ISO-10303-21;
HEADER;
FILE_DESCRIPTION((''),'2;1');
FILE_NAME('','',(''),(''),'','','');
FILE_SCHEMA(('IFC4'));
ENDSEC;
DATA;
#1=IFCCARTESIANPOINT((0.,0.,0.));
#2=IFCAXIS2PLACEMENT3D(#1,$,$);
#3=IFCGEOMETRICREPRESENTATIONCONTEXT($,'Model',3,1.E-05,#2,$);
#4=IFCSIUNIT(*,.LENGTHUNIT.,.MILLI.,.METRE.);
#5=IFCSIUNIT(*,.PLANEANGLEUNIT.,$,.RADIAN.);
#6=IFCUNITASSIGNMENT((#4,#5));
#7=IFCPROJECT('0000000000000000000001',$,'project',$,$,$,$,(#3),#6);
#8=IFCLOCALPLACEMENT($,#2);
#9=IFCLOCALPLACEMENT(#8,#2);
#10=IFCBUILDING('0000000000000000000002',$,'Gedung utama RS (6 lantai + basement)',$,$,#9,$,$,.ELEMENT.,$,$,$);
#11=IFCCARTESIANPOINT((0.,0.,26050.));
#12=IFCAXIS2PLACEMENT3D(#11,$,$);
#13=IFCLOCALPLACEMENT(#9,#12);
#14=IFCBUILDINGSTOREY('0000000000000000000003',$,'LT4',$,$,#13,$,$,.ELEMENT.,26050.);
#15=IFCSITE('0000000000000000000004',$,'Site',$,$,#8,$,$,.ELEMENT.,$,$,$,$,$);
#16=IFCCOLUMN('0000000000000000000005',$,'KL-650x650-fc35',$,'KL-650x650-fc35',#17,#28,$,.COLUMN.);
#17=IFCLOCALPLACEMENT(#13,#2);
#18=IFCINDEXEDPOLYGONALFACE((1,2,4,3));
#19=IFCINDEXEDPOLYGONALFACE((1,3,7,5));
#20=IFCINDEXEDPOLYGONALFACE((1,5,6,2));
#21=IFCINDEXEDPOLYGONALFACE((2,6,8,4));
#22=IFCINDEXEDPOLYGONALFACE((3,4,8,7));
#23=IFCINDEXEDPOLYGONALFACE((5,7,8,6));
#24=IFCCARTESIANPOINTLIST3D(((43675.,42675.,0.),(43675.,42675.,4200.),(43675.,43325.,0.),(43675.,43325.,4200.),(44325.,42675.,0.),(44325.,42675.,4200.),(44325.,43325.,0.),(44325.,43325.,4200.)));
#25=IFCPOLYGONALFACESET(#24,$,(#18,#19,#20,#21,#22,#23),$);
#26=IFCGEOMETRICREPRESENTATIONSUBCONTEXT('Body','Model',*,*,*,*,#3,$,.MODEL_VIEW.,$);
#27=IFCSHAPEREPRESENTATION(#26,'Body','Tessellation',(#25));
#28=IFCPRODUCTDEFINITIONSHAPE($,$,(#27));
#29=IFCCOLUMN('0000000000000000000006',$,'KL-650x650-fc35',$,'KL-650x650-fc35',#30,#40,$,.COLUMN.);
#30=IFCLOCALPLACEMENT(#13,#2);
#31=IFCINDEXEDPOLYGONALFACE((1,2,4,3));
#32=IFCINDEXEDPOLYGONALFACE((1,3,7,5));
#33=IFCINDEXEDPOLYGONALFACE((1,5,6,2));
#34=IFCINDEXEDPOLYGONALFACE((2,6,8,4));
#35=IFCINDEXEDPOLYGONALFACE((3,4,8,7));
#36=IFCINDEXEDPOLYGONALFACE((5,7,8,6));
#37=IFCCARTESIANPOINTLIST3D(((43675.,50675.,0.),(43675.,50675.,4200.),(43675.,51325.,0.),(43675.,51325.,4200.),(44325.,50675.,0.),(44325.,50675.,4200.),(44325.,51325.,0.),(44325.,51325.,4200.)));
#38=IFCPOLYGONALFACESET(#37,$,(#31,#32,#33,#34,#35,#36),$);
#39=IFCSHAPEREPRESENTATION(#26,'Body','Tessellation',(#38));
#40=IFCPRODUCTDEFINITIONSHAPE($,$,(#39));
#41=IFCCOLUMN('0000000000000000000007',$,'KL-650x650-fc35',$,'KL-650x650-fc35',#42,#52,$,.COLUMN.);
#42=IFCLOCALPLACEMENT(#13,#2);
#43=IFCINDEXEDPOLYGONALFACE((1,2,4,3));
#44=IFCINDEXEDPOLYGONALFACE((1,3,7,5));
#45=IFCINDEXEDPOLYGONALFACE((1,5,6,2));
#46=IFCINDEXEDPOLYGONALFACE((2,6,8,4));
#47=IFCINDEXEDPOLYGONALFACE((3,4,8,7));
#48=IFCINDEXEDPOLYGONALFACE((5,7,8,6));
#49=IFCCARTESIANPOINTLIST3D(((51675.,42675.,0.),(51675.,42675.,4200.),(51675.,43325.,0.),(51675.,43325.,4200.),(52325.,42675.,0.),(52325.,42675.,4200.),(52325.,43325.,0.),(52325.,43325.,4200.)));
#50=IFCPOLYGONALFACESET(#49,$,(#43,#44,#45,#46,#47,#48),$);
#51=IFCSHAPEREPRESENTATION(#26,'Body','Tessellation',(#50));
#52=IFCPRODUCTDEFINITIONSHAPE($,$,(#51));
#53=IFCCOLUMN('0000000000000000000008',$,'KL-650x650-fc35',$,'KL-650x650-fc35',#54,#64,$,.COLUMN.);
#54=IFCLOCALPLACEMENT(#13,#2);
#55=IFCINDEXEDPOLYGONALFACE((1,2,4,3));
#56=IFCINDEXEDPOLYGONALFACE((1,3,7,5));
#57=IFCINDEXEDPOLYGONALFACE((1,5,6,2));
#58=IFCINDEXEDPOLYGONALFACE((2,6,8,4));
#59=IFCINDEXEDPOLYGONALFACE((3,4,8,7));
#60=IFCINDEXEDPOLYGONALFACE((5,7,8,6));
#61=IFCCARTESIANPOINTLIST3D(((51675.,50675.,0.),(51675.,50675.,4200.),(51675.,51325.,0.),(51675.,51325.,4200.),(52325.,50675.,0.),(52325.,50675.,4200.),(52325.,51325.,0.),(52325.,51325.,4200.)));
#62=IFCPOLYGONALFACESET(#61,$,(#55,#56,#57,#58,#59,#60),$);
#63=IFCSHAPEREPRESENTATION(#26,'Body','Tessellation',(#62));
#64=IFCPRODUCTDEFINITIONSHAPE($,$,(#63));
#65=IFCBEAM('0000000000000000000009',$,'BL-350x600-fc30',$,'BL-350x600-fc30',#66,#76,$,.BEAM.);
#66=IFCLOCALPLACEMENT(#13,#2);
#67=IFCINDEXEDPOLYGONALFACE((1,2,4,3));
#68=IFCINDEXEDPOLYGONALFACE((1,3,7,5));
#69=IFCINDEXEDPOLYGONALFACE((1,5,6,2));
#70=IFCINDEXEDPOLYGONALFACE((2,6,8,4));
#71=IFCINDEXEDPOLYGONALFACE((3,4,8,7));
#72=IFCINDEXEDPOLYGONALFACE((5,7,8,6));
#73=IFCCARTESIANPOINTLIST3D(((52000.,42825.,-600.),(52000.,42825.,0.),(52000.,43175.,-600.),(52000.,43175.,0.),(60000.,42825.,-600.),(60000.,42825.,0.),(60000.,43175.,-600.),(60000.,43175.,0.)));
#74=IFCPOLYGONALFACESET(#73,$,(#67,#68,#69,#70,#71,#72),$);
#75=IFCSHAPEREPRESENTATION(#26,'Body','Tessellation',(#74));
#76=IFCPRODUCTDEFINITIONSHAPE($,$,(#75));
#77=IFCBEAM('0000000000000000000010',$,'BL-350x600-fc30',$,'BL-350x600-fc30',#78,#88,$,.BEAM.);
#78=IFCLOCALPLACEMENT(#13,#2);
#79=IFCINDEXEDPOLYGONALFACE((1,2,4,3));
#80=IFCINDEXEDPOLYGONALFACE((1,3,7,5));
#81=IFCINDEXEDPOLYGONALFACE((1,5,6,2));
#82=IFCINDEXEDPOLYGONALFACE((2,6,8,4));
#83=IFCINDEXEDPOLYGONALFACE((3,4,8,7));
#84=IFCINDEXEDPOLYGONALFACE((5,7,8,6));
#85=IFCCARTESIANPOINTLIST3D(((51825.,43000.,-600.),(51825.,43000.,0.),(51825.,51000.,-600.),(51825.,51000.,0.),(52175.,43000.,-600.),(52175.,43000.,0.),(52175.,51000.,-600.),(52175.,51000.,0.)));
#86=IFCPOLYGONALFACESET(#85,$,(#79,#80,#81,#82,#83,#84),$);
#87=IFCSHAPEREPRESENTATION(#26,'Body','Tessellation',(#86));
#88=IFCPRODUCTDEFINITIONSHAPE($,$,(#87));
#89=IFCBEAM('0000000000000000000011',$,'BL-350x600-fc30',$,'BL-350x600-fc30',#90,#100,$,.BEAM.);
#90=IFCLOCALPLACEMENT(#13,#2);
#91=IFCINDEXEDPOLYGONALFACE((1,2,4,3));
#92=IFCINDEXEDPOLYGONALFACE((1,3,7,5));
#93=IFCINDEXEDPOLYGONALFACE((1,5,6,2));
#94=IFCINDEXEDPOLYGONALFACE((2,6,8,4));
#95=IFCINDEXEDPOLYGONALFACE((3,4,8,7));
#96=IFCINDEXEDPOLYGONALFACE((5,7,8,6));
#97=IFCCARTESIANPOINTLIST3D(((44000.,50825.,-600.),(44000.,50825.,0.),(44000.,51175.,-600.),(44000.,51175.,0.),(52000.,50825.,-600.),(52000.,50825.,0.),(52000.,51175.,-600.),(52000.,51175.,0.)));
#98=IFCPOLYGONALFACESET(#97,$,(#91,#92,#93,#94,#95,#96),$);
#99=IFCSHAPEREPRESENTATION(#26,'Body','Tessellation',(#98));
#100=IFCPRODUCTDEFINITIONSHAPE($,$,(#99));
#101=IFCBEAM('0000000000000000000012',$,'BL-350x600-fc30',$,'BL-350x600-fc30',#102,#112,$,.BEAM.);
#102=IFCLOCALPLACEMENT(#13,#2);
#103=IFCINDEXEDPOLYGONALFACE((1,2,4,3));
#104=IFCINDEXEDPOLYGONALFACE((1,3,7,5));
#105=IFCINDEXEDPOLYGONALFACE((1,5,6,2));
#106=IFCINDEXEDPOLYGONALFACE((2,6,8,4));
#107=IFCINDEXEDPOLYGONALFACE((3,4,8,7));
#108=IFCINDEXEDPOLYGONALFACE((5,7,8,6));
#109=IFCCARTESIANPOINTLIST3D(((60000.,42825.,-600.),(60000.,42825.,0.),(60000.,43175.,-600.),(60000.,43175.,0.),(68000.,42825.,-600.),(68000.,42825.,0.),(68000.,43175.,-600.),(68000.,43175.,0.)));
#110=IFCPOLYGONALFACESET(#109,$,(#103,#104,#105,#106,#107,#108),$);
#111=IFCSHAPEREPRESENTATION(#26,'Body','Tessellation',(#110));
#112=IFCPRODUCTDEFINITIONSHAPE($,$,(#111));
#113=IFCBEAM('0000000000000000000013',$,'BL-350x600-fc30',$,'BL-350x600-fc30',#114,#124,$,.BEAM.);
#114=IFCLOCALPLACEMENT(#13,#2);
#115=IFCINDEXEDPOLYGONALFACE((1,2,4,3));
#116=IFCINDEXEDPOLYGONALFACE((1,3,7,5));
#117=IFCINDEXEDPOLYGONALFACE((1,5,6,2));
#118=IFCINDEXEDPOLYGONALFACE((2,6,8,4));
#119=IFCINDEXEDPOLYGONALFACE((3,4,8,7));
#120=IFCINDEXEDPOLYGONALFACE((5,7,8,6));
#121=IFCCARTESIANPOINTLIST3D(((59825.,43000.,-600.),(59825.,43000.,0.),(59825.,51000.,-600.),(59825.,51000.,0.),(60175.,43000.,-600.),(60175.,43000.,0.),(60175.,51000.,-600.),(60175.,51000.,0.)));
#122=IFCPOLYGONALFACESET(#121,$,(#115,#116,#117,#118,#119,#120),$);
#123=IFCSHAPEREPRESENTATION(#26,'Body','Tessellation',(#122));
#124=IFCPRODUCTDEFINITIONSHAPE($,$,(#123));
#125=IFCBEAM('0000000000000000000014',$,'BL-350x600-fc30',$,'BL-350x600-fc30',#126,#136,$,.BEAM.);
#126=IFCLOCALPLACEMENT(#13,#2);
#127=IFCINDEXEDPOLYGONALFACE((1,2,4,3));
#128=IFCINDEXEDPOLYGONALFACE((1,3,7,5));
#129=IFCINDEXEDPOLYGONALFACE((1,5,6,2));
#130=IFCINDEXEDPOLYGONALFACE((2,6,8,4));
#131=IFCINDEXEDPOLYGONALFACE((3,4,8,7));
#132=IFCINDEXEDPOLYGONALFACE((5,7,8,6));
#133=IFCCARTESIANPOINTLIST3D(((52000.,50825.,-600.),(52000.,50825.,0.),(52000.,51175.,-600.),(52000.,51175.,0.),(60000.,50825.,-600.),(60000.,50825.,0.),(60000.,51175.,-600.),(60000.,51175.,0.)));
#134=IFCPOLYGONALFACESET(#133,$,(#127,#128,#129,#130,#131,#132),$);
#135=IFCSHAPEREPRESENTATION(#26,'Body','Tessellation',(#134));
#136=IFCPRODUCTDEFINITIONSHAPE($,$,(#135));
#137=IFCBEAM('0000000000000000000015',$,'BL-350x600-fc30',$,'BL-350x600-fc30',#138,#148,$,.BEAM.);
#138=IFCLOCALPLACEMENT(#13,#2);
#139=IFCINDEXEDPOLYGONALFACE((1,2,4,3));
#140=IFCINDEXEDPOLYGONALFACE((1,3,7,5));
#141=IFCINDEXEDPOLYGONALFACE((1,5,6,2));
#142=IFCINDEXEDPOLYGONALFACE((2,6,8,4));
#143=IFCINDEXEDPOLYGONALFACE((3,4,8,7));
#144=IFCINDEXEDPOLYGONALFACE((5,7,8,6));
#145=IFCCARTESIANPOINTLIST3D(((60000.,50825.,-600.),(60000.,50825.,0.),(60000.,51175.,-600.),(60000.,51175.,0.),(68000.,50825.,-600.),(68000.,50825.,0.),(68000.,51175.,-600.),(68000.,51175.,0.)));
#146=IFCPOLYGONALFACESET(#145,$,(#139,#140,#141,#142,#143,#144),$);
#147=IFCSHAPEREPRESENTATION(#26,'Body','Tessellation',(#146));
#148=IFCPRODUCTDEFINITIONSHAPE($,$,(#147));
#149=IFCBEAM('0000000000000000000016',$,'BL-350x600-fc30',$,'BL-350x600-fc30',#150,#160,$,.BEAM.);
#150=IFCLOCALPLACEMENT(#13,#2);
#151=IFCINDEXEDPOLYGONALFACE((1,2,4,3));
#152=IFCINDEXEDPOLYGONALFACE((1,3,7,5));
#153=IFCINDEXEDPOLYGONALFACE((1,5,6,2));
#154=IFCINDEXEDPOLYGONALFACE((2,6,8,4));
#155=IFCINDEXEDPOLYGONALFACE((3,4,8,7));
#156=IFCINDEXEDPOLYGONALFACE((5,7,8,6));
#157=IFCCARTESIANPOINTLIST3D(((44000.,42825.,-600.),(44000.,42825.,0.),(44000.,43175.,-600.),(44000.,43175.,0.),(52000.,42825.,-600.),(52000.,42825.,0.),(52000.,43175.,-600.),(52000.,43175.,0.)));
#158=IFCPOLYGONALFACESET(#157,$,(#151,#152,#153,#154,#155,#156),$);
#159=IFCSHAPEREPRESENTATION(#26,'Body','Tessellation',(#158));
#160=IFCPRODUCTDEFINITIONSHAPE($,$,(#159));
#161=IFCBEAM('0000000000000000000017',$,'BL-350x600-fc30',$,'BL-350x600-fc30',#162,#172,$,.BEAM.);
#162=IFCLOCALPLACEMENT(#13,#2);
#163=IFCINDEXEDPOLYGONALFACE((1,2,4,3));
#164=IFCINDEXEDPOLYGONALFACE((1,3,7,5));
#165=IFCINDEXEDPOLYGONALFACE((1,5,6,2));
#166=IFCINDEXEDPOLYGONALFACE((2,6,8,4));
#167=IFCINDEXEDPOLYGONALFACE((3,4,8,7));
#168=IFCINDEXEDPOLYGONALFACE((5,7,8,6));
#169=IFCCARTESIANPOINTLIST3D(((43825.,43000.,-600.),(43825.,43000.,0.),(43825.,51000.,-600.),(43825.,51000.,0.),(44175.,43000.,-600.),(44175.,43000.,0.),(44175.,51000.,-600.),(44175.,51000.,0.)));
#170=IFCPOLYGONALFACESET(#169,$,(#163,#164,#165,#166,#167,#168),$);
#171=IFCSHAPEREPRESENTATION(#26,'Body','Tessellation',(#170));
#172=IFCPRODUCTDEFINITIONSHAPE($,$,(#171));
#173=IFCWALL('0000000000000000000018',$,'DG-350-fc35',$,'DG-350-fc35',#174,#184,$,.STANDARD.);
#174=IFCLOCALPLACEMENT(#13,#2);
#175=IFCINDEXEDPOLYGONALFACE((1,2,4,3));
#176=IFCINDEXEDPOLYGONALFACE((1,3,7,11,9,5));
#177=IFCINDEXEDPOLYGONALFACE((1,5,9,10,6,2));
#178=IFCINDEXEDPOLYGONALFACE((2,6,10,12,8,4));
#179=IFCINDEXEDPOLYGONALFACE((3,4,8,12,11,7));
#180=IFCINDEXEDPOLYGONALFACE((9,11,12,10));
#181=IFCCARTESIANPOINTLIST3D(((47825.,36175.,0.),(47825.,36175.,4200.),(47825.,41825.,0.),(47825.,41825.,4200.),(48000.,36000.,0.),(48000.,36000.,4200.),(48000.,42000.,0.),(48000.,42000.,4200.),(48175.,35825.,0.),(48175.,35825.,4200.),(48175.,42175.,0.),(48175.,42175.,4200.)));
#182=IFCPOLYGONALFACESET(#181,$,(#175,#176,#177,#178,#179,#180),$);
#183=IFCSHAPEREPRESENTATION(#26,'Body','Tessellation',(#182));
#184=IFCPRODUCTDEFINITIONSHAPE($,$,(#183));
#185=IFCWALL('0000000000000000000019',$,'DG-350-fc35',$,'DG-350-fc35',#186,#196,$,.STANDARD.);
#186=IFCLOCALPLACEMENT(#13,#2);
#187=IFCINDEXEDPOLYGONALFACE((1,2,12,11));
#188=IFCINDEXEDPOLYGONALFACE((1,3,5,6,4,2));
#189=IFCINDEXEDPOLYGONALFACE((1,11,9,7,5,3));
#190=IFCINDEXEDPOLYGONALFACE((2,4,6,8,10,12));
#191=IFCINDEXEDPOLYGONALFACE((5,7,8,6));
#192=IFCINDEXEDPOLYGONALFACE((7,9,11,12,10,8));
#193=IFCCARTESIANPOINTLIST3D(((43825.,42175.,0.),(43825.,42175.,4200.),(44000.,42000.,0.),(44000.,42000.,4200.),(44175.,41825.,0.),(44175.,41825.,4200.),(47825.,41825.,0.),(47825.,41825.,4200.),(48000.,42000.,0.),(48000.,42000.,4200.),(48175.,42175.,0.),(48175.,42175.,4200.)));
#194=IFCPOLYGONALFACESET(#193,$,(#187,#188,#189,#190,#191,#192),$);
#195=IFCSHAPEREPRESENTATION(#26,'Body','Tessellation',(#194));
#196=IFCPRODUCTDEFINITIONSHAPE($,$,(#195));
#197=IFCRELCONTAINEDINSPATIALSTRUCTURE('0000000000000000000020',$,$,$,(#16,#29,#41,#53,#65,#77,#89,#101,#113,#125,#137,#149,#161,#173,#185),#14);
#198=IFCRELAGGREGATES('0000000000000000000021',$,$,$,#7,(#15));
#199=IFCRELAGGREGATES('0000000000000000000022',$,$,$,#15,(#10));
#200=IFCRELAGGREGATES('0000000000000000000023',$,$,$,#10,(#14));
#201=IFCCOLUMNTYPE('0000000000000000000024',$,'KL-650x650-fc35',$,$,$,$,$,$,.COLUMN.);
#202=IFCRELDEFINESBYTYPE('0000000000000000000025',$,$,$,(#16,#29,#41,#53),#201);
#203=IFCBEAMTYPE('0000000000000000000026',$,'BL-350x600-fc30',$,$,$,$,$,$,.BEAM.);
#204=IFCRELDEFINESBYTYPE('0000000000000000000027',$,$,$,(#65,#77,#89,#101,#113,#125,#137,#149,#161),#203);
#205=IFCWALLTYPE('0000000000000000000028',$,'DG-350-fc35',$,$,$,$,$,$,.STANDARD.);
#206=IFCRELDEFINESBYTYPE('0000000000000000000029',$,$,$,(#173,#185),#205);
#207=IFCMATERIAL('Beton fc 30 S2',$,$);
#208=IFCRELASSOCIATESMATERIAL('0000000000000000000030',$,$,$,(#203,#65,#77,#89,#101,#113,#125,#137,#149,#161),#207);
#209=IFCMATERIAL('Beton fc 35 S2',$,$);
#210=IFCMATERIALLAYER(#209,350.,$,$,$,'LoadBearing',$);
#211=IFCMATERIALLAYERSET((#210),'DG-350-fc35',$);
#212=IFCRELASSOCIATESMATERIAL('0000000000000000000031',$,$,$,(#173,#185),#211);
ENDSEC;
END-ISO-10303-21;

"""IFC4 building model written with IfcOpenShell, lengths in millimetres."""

from ifc_helpers import new_model, si_unit, frame, origin, origin_2d, place, context, subcontext, project, spatial, polyline, rectangle, outline, extrude, material, layer, layer_set, layer_usage, material_profile, profile_set, profile_usage, type_object, element, save


model = new_model("IFC4")

# Units and contexts
model_context = context("Model", 3, precision=1e-05, world=origin())
body_context = subcontext(model_context, "Body", "Model", "MODEL_VIEW")
ifc_project = project(units=[si_unit("LENGTHUNIT", "METRE", prefix="MILLI"), si_unit("PLANEANGLEUNIT", "RADIAN")], contexts=[model_context])

# Site, building, storey
site_placement = place(None, origin())
site = spatial("IfcSite", under=ifc_project, at=site_placement, Name="Site", CompositionType="ELEMENT")
building_placement = place(site_placement, origin())
building = spatial("IfcBuilding", under=site, at=building_placement, Name="Gedung utama RS (6 lantai + basement)", CompositionType="ELEMENT")
storey_placement = place(building_placement, frame((0.0, 0.0, 26050.0)))
storey = spatial("IfcBuildingStorey", under=building, at=storey_placement, Name="LT4", CompositionType="ELEMENT", Elevation=26050.0)

# Columns
ifc_material_profile_1 = material_profile(None, rectangle(XDim=650.0, YDim=650.0, at=origin_2d()), Name="KL-650x650-fc35")
ifc_profile_set_1 = profile_set([ifc_material_profile_1], Name="KL-650x650-fc35")
ifc_profile_usage_1 = profile_usage(ifc_profile_set_1, cardinal=5)
column_type = type_object("IfcColumnType", Name="KL-650x650-fc35", PredefinedType="COLUMN", material=ifc_profile_set_1)
for number, where, z_axis, x_axis, name in (
    (1, (44000.0, 43000.0, 0.0), (0.0, 0.0, 1.0), (1.0, 0.0, 0.0), "KL-650x650-fc35"),
    (2, (44000.0, 51000.0, 0.0), (0.0, 0.0, 1.0), (1.0, 0.0, 0.0), "KL-650x650-fc35"),
    (3, (52000.0, 43000.0, 0.0), (0.0, 0.0, 1.0), (1.0, 0.0, 0.0), "KL-650x650-fc35"),
    (4, (52000.0, 51000.0, 0.0), (0.0, 0.0, 1.0), (1.0, 0.0, 0.0), "KL-650x650-fc35"),
):
    element("IfcColumn", number, at=place(storey_placement, frame(where, z_axis=z_axis, x_axis=x_axis)), inside=storey, type_object=column_type, material=ifc_profile_usage_1, Name=name, ObjectType="KL-650x650-fc35", PredefinedType="COLUMN", context=body_context, shape_type="SweptSolid", body=[
        extrude(rectangle(XDim=650.0, YDim=650.0, at=origin_2d()), origin(), (0.0, 0.0, 1.0), 4200.0),
    ])

# Beams
ifc_material_1 = material(Name="Beton fc 30 S2")
ifc_material_profile_2 = material_profile(ifc_material_1, rectangle(XDim=350.0, YDim=600.0, at=origin_2d()), Name="BL-350x600-fc30")
ifc_profile_set_2 = profile_set([ifc_material_profile_2], Name="BL-350x600-fc30")
ifc_profile_usage_2 = profile_usage(ifc_profile_set_2, cardinal=8)
beam_type = type_object("IfcBeamType", Name="BL-350x600-fc30", PredefinedType="BEAM", material=ifc_profile_set_2)
beam_1_placement = place(storey_placement, frame((52000.0, 43000.0, -300.0)))
element("IfcBeam", 5, at=beam_1_placement, inside=storey, type_object=beam_type, material=ifc_profile_usage_2, Name="BL-350x600-fc30", ObjectType="BL-350x600-fc30", PredefinedType="BEAM", context=body_context, shape_type="SweptSolid", body=[
    extrude(rectangle(XDim=350.0, YDim=600.0, at=origin_2d()), frame((0.0, 0.0, 0.0), z_axis=(1.0, 0.0, 0.0), x_axis=(0.0, 1.0, 0.0)), (0.0, 0.0, 1.0), 8000.0),
])
beam_2_placement = place(storey_placement, frame((52000.0, 43000.0, -300.0)))
element("IfcBeam", 6, at=beam_2_placement, inside=storey, type_object=beam_type, material=ifc_profile_usage_2, Name="BL-350x600-fc30", ObjectType="BL-350x600-fc30", PredefinedType="BEAM", context=body_context, shape_type="SweptSolid", body=[
    extrude(rectangle(XDim=350.0, YDim=600.0, at=origin_2d()), frame((0.0, 0.0, 0.0), z_axis=(0.0, 1.0, 0.0), x_axis=(-1.0, 0.0, 0.0)), (0.0, 0.0, 1.0), 8000.0),
])
for number, where, name in (
    (7, (44000.0, 51000.0, -300.0), "BL-350x600-fc30"),
    (8, (60000.0, 43000.0, -300.0), "BL-350x600-fc30"),
):
    element("IfcBeam", number, at=place(storey_placement, frame(where)), inside=storey, type_object=beam_type, material=ifc_profile_usage_2, Name=name, ObjectType="BL-350x600-fc30", PredefinedType="BEAM", context=body_context, shape_type="SweptSolid", body=[
        extrude(rectangle(XDim=350.0, YDim=600.0, at=origin_2d()), frame((0.0, 0.0, 0.0), z_axis=(1.0, 0.0, 0.0), x_axis=(0.0, 1.0, 0.0)), (0.0, 0.0, 1.0), 8000.0),
    ])
beam_3_placement = place(storey_placement, frame((60000.0, 43000.0, -300.0)))
element("IfcBeam", 9, at=beam_3_placement, inside=storey, type_object=beam_type, material=ifc_profile_usage_2, Name="BL-350x600-fc30", ObjectType="BL-350x600-fc30", PredefinedType="BEAM", context=body_context, shape_type="SweptSolid", body=[
    extrude(rectangle(XDim=350.0, YDim=600.0, at=origin_2d()), frame((0.0, 0.0, 0.0), z_axis=(0.0, 1.0, 0.0), x_axis=(-1.0, 0.0, 0.0)), (0.0, 0.0, 1.0), 8000.0),
])
for number, where, name in (
    (10, (52000.0, 51000.0, -300.0), "BL-350x600-fc30"),
    (11, (60000.0, 51000.0, -300.0), "BL-350x600-fc30"),
    (12, (44000.0, 43000.0, -300.0), "BL-350x600-fc30"),
):
    element("IfcBeam", number, at=place(storey_placement, frame(where)), inside=storey, type_object=beam_type, material=ifc_profile_usage_2, Name=name, ObjectType="BL-350x600-fc30", PredefinedType="BEAM", context=body_context, shape_type="SweptSolid", body=[
        extrude(rectangle(XDim=350.0, YDim=600.0, at=origin_2d()), frame((0.0, 0.0, 0.0), z_axis=(1.0, 0.0, 0.0), x_axis=(0.0, 1.0, 0.0)), (0.0, 0.0, 1.0), 8000.0),
    ])
beam_4_placement = place(storey_placement, frame((44000.0, 43000.0, -300.0)))
element("IfcBeam", 13, at=beam_4_placement, inside=storey, type_object=beam_type, material=ifc_profile_usage_2, Name="BL-350x600-fc30", ObjectType="BL-350x600-fc30", PredefinedType="BEAM", context=body_context, shape_type="SweptSolid", body=[
    extrude(rectangle(XDim=350.0, YDim=600.0, at=origin_2d()), frame((0.0, 0.0, 0.0), z_axis=(0.0, 1.0, 0.0), x_axis=(-1.0, 0.0, 0.0)), (0.0, 0.0, 1.0), 8000.0),
])

# Walls
ifc_material_2 = material(Name="Beton fc 35 S2")
ifc_layer = layer(ifc_material_2, 350.0, Category="LoadBearing")
ifc_layer_set = layer_set([ifc_layer], Name="DG-350-fc35")
ifc_layer_usage = layer_usage(ifc_layer_set, "AXIS2", "NEGATIVE", 175.0)
wall_type = type_object("IfcWallType", Name="DG-350-fc35", PredefinedType="STANDARD")
wall_1_placement = place(storey_placement, frame((48000.0, 36000.0, 0.0), z_axis=(0.0, 0.0, 1.0), x_axis=(0.0, 1.0, 0.0)))
element("IfcWall", 14, at=wall_1_placement, inside=storey, type_object=wall_type, material=ifc_layer_usage, Name="DG-350-fc35", ObjectType="DG-350-fc35", PredefinedType="STANDARD", context=body_context, shape_type="SweptSolid", body=[
    extrude(outline(polyline([(-175.0, -175.0), (0.0, 0.0), (175.0, 175.0), (5825.0, 175.0), (6000.0, 0.0), (6175.0, -175.0), (-175.0, -175.0)])), origin(), (0.0, 0.0, 1.0), 4200.0),
])
wall_2_placement = place(storey_placement, frame((48000.0, 42000.0, 0.0), z_axis=(0.0, 0.0, 1.0), x_axis=(-1.0, 0.0, 0.0)))
element("IfcWall", 15, at=wall_2_placement, inside=storey, type_object=wall_type, material=ifc_layer_usage, Name="DG-350-fc35", ObjectType="DG-350-fc35", PredefinedType="STANDARD", context=body_context, shape_type="SweptSolid", body=[
    extrude(outline(polyline([(-175.0, -175.0), (0.0, 0.0), (175.0, 175.0), (3825.0, 175.0), (4000.0, 0.0), (4175.0, -175.0), (-175.0, -175.0)])), origin(), (0.0, 0.0, 1.0), 4200.0),
])

save(model, "model.ifc")
